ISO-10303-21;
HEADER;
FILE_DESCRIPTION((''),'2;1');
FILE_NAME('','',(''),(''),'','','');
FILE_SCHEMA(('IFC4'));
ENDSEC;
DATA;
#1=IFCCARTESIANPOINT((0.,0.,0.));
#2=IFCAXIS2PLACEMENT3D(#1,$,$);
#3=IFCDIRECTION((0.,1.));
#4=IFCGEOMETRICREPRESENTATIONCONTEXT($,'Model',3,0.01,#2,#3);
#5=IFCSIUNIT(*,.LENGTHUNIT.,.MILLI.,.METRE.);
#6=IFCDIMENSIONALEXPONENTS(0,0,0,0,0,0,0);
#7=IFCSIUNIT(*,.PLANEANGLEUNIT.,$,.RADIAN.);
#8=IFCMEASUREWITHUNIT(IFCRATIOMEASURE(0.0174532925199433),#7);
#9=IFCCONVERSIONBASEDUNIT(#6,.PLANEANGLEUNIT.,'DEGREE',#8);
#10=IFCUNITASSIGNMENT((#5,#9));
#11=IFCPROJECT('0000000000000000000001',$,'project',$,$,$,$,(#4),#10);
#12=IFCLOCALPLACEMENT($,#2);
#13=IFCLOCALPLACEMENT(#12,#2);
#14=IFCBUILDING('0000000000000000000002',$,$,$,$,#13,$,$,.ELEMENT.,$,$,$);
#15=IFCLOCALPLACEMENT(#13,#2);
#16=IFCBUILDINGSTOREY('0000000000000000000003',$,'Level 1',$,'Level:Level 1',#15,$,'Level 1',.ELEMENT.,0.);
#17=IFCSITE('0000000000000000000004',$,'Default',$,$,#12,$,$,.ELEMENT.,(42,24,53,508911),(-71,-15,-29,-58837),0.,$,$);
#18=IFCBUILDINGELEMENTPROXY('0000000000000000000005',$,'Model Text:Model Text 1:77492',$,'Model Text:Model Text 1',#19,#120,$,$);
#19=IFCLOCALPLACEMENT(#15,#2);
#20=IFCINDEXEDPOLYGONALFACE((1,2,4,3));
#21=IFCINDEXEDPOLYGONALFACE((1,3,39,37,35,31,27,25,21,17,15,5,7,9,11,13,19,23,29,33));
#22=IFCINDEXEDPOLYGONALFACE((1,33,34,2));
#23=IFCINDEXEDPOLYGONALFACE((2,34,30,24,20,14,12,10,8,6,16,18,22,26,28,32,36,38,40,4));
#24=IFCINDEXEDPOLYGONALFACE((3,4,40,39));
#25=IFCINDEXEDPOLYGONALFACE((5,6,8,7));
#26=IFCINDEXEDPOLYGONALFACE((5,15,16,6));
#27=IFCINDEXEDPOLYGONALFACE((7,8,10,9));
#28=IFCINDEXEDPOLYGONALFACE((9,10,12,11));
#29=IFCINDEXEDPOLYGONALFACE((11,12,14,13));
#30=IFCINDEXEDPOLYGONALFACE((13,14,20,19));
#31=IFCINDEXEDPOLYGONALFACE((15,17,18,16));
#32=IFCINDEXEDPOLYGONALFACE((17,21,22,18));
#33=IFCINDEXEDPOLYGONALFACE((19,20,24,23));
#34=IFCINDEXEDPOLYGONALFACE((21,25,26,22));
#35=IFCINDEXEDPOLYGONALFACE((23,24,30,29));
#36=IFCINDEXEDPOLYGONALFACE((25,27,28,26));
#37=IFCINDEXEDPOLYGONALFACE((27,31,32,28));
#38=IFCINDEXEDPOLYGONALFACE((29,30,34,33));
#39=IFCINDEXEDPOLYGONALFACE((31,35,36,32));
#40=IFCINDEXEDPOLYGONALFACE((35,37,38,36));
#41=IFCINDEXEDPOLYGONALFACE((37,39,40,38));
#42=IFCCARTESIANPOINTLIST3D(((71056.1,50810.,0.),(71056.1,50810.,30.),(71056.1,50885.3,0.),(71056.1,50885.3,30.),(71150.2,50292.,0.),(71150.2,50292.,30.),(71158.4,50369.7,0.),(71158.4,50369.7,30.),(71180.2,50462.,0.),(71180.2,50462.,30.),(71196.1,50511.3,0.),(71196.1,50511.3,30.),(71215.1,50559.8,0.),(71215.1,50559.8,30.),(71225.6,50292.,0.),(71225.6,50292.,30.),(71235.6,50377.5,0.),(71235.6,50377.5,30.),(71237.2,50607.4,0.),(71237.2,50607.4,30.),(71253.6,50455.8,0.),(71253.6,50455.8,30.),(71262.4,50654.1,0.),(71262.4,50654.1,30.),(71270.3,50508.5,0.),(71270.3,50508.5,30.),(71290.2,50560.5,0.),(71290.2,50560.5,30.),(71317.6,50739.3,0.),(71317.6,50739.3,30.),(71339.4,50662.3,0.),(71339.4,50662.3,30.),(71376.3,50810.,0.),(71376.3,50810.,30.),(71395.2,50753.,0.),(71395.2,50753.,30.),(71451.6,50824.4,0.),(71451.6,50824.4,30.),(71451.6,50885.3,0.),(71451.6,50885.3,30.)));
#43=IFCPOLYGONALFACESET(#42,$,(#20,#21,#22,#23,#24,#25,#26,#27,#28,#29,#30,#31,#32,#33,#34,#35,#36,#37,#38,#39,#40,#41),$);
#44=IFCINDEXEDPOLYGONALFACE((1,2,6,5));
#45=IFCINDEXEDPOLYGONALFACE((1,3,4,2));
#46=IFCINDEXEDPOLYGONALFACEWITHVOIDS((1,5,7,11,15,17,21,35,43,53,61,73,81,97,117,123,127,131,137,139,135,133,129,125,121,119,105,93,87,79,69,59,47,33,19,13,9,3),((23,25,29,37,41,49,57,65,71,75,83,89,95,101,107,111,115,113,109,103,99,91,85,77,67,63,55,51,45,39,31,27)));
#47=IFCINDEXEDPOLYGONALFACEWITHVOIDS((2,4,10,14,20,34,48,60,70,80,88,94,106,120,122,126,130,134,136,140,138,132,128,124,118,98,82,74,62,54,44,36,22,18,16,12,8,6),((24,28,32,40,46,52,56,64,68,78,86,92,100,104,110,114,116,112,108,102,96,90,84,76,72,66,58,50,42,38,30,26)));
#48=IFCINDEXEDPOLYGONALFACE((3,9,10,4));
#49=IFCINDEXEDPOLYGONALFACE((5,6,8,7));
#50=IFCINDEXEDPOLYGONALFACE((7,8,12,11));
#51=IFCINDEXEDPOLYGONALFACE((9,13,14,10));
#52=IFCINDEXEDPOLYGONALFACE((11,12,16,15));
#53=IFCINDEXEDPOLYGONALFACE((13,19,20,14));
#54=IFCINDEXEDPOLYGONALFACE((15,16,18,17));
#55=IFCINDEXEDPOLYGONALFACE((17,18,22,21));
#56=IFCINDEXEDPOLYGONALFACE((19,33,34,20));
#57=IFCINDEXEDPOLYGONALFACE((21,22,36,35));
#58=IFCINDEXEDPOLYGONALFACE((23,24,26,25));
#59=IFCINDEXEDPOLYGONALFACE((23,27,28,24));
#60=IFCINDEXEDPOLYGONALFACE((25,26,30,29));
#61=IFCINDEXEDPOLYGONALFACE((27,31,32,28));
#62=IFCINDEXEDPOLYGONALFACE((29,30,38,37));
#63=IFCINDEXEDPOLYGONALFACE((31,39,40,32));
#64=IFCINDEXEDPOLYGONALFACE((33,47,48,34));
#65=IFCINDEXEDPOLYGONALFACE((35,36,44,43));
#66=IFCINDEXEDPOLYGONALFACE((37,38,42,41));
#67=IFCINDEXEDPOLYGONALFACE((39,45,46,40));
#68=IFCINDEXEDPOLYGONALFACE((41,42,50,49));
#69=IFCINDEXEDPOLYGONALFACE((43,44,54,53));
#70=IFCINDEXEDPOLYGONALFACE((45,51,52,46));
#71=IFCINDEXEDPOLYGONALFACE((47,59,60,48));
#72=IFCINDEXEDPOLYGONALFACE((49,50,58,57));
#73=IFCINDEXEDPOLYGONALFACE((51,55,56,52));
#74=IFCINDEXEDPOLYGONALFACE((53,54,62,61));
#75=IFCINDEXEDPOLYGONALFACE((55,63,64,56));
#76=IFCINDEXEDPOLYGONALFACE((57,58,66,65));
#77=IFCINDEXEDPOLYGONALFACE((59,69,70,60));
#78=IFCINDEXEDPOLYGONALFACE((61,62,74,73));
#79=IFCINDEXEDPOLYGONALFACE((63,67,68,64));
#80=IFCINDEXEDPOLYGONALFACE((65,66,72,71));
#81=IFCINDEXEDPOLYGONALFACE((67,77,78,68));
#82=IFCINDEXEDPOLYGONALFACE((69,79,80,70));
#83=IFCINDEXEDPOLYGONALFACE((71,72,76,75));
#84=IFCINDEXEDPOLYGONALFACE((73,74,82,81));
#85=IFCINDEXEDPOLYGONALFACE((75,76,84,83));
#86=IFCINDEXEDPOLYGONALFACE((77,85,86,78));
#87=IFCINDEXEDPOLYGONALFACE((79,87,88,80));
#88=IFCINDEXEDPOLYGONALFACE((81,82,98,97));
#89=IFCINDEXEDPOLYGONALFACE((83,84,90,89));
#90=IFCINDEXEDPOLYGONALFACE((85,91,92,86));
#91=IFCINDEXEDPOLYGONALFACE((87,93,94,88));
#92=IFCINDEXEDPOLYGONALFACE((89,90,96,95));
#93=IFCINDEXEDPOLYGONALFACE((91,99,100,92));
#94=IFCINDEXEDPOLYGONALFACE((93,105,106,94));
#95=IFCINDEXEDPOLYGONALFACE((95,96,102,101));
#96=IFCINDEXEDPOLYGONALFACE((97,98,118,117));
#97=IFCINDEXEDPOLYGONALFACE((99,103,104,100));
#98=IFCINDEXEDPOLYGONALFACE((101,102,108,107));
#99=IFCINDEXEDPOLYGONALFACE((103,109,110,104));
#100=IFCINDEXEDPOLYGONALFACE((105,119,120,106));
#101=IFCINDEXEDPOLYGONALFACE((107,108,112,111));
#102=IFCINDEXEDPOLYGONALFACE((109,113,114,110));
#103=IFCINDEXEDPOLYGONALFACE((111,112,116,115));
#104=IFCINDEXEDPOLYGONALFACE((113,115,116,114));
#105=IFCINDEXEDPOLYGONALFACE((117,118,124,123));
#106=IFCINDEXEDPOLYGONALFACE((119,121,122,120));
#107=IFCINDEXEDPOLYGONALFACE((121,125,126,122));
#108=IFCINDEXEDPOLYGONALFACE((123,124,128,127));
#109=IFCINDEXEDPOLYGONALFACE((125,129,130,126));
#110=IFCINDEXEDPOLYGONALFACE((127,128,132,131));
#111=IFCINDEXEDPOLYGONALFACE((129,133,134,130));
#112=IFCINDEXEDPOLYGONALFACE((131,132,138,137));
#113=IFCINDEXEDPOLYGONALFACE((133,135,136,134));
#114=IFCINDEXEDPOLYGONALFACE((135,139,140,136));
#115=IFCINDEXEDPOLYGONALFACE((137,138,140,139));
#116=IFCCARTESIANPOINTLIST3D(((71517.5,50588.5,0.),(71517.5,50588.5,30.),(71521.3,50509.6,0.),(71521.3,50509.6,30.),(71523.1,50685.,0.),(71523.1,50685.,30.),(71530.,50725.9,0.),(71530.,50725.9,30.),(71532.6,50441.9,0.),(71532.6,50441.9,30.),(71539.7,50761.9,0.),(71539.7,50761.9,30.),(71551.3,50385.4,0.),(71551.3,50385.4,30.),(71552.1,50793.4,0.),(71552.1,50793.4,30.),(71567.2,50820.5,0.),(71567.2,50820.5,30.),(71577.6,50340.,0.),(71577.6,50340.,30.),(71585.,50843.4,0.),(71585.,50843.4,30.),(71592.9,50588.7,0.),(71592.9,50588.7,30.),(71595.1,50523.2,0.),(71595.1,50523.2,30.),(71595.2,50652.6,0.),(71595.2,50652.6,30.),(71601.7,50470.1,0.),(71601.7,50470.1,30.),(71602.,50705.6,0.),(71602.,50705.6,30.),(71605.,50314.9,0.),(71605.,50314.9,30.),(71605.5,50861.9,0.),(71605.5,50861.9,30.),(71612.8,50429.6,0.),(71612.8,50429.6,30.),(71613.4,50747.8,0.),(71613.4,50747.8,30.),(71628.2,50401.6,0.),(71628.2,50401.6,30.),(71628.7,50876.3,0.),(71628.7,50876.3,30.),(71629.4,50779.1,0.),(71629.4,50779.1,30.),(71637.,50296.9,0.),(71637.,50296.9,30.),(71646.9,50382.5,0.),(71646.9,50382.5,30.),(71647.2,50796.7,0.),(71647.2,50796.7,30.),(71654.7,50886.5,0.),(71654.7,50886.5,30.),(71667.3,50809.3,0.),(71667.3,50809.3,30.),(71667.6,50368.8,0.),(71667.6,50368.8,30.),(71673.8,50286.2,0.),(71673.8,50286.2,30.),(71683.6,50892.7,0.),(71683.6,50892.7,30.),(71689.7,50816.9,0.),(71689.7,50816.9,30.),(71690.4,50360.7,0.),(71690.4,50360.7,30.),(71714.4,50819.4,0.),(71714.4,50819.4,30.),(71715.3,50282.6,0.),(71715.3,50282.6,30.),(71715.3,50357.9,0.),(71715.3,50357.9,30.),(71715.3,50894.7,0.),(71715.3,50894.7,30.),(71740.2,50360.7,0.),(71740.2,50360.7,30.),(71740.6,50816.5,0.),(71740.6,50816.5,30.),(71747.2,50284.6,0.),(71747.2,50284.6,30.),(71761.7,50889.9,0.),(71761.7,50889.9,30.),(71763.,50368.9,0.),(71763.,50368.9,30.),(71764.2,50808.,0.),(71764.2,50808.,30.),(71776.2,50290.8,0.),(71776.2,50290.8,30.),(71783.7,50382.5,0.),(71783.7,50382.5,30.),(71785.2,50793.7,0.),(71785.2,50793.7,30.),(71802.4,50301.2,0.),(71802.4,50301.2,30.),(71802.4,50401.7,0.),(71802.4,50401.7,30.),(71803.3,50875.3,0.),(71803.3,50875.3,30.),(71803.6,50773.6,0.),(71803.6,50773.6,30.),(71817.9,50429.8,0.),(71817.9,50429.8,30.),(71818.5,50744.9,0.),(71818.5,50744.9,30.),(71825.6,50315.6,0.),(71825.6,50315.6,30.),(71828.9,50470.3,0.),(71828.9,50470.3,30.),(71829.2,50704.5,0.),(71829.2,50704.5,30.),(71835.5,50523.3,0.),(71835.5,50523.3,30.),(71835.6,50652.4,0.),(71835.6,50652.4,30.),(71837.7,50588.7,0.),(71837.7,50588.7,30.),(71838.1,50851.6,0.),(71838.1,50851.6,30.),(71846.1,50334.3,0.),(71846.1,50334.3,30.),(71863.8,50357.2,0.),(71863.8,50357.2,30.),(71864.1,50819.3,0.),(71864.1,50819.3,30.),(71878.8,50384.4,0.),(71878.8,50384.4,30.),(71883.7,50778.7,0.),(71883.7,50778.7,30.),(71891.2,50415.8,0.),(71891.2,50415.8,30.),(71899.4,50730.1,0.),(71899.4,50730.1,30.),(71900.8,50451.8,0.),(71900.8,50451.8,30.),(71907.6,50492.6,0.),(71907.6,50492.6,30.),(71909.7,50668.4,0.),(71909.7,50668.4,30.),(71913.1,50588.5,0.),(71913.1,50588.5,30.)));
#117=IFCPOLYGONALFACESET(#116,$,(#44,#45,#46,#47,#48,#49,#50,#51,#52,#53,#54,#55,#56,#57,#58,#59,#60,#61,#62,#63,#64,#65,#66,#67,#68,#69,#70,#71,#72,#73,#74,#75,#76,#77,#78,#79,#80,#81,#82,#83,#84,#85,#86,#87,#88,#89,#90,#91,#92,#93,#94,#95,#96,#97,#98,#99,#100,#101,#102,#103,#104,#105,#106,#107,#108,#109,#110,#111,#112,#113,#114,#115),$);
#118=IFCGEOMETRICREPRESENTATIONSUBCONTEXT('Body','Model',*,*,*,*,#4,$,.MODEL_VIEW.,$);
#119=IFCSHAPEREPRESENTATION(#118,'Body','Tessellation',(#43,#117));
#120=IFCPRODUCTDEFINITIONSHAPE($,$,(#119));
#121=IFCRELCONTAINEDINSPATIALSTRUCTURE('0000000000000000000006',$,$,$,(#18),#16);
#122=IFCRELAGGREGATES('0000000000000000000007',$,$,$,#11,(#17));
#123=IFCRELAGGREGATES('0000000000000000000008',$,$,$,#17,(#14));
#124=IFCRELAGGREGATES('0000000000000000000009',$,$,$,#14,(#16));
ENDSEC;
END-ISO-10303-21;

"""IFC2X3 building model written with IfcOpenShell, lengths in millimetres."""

from ifc_helpers import new_model, entity, si_unit, converted_unit, direction, frame, origin, place, context, subcontext, project, spatial, polyline, outline, extrude, element, save


model = new_model("IFC2X3")

# Units and contexts
model_context = context("Model", 3, precision=0.01, world=origin(), true_north=direction((0.0, 1.0)))
body_context = subcontext(model_context, "Body", "Model", "MODEL_VIEW")
ifc_project = project(units=[si_unit("LENGTHUNIT", "METRE", prefix="MILLI"), converted_unit("PLANEANGLEUNIT", "DEGREE", entity("IfcRatioMeasure", 0.0174532925199433), si_unit("PLANEANGLEUNIT", "RADIAN"), dimensions=[0, 0, 0, 0, 0, 0, 0])], contexts=[model_context])

# Site, building, storey
site_placement = place(None, origin())
site = spatial("IfcSite", under=ifc_project, at=site_placement, Name="Default", CompositionType="ELEMENT", RefLatitude=(42, 24, 53, 508911), RefLongitude=(-71, -15, -29, -58837), RefElevation=0.0)
building_placement = place(site_placement, origin())
building = spatial("IfcBuilding", under=site, at=building_placement, CompositionType="ELEMENT")
storey_placement = place(building_placement, origin())
storey = spatial("IfcBuildingStorey", under=building, at=storey_placement, Name="Level 1", ObjectType="Level:Level 1", LongName="Level 1", CompositionType="ELEMENT", Elevation=0.0)

# Building element proxy
proxy_1_placement = place(storey_placement, origin())
element("IfcBuildingElementProxy", 1, at=proxy_1_placement, inside=storey, Name="Model Text:Model Text 1:77492", ObjectType="Model Text:Model Text 1", context=body_context, shape_type="SweptSolid", body=[
    extrude(outline(polyline([(-199.9, -209.0), (-199.9, -284.3), (195.7, -284.3), (195.7, -223.4), (139.3, -152.0), (83.5, -61.3), (34.2, 40.5), (14.4, 92.5), (-2.4, 145.2), (-20.3, 223.5), (-30.3, 309.0), (-105.7, 309.0), (-97.5, 231.3), (-75.7, 139.0), (-59.9, 89.7), (-40.9, 41.2), (-18.8, -6.4), (6.4, -53.1), (61.7, -138.3), (120.3, -209.0), (-199.9, -209.0)])), frame((71255.9, 50601.0, 0.0), z_axis=(0.0, 0.0, -1.0), x_axis=(1.0, 0.0, 0.0)), (0.0, 0.0, -1.0), 30.0),
    extrude(outline(polyline([(-10.6, -198.7), (68.3, -198.7), (136.5, -190.7), (193.9, -174.7), (240.5, -150.6), (266.9, -124.4), (286.3, -93.2), (298.8, -57.0), (304.3, -15.7), (303.8, 16.2), (299.0, 45.5), (289.9, 72.1), (276.6, 96.0), (258.9, 117.3), (236.9, 136.2), (210.4, 152.5), (179.6, 166.3), (144.1, 177.6), (103.7, 186.3), (8.2, 196.4), (-71.8, 196.7), (-134.0, 189.4), (-183.3, 176.1), (-224.7, 158.4), (-258.2, 133.9), (-283.5, 100.3), (-300.1, 59.5), (-307.1, 13.4), (-306.6, -18.4), (-301.8, -47.5), (-292.8, -74.0), (-279.6, -97.9), (-262.0, -119.2), (-240.0, -138.1), (-213.6, -154.5), (-182.8, -168.4), (-147.3, -179.8), (-106.7, -188.6), (-10.6, -198.7)]), holes=[polyline([(-7.2, -123.5), (-71.0, -118.2), (-123.6, -108.8), (-165.2, -95.4), (-195.7, -78.0), (-212.4, -59.4), (-224.1, -38.7), (-230.6, -15.9), (-231.9, 8.9), (-227.8, 35.0), (-218.1, 58.1), (-202.8, 78.4), (-182.0, 95.8), (-152.6, 109.4), (-111.7, 118.1), (-59.4, 122.0), (4.4, 121.1), (69.6, 115.8), (122.2, 106.7), (162.2, 93.7), (189.5, 77.0), (207.7, 57.4), (220.4, 36.0), (227.5, 12.8), (229.1, -12.1), (225.2, -36.8), (215.9, -59.2), (201.3, -79.3), (181.4, -97.1), (152.6, -111.2), (111.6, -120.3), (58.3, -124.4), (-7.2, -123.5)])]), frame((71716.6, 50587.3, 0.0), z_axis=(0.0, 0.0, 1.0), x_axis=(0.047515, -0.998871, 0.0)), (0.0, 0.0, 1.0), 30.0),
])

save(model, "model.ifc")
